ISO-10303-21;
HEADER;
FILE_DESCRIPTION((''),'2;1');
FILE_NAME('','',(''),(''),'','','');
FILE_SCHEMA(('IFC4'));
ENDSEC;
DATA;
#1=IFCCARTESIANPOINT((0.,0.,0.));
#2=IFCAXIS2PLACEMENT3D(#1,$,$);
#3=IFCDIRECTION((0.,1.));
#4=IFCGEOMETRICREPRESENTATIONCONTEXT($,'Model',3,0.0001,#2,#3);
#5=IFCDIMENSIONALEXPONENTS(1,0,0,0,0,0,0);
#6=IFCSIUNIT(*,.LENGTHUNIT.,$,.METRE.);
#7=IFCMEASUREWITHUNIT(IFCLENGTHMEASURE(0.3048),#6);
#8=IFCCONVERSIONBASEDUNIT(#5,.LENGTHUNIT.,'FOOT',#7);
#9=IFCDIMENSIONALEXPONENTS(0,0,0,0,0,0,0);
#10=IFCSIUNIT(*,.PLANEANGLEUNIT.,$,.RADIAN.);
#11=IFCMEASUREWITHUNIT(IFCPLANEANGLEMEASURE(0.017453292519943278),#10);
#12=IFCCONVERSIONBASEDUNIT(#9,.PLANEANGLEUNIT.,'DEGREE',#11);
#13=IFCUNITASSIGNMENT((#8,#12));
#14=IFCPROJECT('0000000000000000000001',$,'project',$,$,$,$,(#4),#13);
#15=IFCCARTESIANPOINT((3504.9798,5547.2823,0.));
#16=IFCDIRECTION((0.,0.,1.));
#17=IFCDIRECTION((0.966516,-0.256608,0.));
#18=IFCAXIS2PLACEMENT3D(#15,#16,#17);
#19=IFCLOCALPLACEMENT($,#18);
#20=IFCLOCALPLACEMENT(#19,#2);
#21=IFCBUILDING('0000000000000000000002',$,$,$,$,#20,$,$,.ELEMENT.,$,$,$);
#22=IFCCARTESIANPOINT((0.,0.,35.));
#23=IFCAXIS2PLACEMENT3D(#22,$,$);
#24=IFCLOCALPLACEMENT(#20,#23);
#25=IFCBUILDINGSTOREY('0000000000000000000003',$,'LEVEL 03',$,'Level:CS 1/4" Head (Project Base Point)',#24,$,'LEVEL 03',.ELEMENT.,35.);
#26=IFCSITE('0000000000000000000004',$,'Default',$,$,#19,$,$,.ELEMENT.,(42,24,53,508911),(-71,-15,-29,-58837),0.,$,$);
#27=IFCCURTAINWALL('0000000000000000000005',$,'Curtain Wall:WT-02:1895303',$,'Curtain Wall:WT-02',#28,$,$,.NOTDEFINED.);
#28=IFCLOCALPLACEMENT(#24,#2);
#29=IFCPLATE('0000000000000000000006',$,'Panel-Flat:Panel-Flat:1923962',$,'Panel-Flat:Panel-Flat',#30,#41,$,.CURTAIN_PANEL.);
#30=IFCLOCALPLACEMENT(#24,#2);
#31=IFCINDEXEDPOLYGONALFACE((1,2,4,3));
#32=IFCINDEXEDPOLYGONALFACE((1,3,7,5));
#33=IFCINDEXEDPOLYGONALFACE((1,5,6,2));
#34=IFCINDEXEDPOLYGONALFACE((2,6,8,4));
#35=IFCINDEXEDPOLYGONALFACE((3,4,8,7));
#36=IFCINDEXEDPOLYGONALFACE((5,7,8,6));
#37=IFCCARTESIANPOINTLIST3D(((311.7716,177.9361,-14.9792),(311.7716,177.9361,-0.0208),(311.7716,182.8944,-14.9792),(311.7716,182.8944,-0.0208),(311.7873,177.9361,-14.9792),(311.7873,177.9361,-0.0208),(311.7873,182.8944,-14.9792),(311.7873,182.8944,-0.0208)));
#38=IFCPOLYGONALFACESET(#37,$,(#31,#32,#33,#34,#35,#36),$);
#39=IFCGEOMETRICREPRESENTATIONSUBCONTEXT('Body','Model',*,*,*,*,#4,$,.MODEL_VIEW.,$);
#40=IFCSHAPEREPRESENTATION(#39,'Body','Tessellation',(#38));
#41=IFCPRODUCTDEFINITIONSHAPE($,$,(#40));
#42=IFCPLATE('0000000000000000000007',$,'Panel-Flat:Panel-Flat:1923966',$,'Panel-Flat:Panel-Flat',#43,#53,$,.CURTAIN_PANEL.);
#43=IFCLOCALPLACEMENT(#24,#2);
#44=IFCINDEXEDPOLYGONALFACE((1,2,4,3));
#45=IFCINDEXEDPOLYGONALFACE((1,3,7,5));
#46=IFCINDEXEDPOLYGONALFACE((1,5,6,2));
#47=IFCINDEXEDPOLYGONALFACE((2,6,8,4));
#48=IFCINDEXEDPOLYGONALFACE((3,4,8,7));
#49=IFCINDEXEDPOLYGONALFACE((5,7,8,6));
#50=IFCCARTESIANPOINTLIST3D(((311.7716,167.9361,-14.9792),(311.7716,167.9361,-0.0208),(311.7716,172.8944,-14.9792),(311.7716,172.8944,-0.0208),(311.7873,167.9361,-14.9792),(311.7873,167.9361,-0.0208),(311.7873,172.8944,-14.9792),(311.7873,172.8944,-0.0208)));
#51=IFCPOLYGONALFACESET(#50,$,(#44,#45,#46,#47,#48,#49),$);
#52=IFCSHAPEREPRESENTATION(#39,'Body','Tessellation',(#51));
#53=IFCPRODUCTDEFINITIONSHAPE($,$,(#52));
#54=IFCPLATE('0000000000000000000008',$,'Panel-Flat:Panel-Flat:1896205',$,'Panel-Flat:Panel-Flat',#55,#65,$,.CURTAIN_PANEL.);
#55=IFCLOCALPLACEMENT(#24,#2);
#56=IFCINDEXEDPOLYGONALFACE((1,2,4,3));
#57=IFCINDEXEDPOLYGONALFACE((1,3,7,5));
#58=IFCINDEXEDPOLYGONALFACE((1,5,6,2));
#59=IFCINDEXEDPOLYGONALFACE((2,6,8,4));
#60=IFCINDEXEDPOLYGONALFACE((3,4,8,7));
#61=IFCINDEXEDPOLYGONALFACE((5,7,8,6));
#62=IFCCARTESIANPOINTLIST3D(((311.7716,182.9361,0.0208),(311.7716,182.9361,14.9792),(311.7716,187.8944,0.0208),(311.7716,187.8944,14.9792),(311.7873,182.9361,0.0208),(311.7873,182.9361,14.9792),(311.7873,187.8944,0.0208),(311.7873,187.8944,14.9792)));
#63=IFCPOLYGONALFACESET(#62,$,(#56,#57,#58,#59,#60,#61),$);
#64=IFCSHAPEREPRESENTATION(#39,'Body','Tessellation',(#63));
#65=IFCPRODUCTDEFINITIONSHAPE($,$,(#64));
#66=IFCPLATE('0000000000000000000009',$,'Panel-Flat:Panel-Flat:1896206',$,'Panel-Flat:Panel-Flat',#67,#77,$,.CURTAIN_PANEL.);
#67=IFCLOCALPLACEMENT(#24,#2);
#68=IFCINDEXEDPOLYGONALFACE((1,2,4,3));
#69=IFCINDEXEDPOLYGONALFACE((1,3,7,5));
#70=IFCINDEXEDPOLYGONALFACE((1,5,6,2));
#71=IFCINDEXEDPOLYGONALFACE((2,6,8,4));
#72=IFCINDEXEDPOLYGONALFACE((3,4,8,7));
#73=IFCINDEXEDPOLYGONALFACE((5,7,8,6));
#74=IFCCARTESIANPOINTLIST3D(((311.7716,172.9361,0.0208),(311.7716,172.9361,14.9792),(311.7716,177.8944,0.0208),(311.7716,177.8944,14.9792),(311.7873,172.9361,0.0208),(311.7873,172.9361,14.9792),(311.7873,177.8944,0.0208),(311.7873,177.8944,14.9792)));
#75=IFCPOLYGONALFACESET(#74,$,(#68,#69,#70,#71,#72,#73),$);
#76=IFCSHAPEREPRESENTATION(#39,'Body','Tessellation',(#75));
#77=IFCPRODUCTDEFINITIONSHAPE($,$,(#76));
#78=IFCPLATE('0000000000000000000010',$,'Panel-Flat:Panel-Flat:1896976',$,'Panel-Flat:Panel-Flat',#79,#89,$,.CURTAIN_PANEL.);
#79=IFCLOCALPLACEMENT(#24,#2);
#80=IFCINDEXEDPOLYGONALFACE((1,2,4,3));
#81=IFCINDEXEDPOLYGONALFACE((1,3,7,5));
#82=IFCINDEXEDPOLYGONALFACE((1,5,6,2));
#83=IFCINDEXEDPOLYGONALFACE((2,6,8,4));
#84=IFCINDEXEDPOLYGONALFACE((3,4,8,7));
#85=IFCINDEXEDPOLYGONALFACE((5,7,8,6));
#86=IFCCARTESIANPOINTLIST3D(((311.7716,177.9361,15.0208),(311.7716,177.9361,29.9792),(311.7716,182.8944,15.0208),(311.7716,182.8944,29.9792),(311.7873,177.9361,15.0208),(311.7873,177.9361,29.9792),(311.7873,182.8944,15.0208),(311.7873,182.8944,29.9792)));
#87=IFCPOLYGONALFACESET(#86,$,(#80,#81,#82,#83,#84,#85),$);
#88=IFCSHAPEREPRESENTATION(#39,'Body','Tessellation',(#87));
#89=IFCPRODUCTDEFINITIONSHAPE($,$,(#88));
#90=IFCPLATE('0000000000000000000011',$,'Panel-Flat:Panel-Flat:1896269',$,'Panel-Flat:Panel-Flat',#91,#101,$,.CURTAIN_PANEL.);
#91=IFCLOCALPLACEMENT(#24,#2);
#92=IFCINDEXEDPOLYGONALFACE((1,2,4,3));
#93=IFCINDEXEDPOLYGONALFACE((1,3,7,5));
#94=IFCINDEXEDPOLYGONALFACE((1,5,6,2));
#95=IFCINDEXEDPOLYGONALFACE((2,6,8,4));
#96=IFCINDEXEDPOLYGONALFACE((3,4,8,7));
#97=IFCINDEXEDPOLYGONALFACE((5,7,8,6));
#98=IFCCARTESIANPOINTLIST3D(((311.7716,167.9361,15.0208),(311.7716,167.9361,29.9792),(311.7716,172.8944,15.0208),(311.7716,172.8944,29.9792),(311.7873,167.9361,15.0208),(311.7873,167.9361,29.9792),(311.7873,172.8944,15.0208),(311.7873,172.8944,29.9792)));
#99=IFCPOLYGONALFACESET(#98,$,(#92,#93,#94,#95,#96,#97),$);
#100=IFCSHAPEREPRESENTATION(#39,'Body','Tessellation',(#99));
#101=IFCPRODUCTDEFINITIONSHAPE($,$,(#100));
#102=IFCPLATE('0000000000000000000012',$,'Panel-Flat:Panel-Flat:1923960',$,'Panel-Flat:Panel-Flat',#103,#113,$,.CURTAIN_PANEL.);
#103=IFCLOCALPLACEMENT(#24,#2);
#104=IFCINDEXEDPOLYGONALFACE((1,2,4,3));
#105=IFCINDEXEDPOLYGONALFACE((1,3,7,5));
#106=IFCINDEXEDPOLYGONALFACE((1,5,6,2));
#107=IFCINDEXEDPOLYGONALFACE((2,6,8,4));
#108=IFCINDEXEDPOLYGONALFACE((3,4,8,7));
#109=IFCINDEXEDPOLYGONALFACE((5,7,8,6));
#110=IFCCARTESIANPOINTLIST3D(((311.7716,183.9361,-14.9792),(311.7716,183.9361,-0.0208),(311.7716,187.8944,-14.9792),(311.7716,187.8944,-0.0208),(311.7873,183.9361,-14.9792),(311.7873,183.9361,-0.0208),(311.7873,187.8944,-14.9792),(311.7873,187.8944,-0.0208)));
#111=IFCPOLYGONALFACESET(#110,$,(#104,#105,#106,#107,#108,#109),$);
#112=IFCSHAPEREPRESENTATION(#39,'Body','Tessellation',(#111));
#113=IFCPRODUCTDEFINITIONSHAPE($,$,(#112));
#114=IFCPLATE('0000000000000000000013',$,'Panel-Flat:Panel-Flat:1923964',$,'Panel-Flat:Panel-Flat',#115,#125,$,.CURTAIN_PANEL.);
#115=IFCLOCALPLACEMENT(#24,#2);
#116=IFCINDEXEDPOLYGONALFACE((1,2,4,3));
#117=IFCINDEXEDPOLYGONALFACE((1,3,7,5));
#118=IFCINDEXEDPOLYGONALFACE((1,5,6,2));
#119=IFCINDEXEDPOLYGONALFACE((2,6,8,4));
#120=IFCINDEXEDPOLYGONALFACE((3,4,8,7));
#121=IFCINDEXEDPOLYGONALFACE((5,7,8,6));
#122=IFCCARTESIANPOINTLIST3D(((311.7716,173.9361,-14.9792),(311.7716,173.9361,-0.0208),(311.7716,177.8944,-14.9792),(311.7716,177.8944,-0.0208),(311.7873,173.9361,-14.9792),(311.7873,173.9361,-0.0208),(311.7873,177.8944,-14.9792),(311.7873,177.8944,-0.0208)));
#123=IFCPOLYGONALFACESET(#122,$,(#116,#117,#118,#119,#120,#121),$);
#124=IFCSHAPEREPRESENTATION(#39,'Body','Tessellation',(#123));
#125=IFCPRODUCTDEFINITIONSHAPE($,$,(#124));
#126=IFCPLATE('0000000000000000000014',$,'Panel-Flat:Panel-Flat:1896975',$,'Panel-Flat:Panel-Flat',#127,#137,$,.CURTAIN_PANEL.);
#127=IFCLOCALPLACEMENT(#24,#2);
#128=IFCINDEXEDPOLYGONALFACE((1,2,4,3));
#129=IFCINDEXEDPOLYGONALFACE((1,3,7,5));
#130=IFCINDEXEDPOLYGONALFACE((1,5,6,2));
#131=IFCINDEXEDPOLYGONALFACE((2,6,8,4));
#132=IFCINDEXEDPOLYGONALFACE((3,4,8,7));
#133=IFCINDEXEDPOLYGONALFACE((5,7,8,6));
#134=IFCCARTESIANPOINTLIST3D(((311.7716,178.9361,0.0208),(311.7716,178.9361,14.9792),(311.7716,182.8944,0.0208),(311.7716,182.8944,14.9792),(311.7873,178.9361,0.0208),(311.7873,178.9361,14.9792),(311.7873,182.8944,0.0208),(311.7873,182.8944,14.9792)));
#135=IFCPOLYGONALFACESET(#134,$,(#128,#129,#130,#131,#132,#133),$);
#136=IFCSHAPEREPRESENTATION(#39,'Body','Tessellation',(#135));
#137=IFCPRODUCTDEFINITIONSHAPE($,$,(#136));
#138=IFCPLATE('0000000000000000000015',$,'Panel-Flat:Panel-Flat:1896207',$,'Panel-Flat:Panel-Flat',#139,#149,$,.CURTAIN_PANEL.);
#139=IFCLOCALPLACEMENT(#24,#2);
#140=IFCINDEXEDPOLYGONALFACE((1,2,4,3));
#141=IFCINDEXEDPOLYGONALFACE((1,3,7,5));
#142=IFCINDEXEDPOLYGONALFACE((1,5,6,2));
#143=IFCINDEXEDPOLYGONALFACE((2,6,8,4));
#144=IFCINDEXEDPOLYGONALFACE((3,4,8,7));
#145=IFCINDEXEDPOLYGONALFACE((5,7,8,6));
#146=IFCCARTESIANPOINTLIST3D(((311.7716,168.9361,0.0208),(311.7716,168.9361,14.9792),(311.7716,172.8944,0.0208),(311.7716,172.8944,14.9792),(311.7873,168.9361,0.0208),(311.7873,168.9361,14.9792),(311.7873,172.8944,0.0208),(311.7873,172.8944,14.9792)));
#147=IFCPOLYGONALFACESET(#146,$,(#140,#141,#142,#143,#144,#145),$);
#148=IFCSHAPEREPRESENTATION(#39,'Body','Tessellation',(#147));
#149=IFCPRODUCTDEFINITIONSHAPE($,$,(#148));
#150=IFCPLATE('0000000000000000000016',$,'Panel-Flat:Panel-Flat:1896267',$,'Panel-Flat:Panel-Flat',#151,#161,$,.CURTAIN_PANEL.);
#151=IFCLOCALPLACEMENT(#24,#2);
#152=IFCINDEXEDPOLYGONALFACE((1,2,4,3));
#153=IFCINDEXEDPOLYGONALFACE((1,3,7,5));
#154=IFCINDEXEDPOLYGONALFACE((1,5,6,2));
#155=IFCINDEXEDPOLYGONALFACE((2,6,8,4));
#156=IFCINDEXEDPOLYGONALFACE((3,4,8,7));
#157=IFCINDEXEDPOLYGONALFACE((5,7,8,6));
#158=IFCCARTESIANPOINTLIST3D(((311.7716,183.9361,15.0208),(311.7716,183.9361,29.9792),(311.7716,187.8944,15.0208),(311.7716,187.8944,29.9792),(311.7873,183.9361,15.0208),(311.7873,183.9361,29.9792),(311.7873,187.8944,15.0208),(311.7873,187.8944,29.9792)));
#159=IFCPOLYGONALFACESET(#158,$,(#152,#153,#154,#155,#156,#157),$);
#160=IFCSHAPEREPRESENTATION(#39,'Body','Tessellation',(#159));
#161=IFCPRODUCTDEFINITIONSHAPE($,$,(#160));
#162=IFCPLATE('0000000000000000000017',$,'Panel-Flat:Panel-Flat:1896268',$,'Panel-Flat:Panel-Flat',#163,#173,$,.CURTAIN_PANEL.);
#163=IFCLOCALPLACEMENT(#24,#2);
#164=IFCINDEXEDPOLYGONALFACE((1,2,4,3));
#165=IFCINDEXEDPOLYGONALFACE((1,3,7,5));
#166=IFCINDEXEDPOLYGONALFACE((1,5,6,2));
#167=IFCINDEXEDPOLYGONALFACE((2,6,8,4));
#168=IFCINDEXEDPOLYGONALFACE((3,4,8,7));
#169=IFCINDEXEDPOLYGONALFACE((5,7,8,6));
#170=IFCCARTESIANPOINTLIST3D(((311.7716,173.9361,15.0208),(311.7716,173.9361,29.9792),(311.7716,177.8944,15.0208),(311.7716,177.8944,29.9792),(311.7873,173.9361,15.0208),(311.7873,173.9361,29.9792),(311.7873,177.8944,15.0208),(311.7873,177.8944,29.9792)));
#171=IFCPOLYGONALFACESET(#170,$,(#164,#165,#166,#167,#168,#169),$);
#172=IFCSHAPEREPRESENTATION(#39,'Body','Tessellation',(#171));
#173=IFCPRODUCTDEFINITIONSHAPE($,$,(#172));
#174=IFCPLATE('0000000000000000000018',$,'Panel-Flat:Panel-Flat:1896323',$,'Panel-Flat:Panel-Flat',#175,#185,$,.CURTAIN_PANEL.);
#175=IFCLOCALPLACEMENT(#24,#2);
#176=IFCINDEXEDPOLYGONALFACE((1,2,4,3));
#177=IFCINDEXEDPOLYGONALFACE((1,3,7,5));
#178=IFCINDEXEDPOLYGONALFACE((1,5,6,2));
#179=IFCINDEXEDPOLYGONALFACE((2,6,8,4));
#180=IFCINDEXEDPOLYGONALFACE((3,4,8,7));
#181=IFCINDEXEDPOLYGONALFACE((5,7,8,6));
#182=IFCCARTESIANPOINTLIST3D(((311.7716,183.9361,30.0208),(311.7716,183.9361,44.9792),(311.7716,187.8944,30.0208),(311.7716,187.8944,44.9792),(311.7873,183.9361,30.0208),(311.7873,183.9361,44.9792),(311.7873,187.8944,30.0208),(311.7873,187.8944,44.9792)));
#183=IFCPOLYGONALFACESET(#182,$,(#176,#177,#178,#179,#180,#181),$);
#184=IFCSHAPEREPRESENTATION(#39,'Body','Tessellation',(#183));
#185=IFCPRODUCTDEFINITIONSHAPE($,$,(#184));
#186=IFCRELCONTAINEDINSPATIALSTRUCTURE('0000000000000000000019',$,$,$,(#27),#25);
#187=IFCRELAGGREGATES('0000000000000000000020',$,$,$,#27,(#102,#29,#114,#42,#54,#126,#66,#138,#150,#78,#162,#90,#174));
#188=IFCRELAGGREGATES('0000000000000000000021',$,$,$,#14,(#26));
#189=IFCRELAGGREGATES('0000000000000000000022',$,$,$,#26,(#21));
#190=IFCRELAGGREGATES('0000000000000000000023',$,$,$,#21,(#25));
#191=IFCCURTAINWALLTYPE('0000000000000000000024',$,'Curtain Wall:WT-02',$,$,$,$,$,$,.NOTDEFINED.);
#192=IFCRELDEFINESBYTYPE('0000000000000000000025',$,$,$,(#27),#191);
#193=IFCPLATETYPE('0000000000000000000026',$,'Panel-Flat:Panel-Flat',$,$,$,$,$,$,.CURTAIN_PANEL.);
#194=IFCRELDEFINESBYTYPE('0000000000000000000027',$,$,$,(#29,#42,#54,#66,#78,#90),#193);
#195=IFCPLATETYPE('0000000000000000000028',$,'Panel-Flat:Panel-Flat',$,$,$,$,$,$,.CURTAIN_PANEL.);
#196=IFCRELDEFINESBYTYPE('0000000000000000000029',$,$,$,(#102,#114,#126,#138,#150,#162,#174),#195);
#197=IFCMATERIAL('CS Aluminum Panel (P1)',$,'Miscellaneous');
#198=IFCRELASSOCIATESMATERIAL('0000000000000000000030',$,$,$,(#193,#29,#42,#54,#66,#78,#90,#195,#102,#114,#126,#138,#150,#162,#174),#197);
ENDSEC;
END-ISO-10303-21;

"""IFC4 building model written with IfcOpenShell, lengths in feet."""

from ifc_helpers import new_model, entity, si_unit, converted_unit, direction, frame, origin, place, context, subcontext, project, spatial, indexed_curve, outline, extrude, source, transform, mapped, material, type_object, type_shapes, element, aggregate, save


model = new_model("IFC4")

# Units and contexts
model_context = context("Model", 3, precision=0.0001, world=origin(), true_north=direction((0.0, 1.0)))
body_context = subcontext(model_context, "Body", "Model", "MODEL_VIEW")
ifc_project = project(units=[converted_unit("LENGTHUNIT", "FOOT", entity("IfcLengthMeasure", 0.3048), si_unit("LENGTHUNIT", "METRE"), dimensions=[1, 0, 0, 0, 0, 0, 0]), converted_unit("PLANEANGLEUNIT", "DEGREE", entity("IfcPlaneAngleMeasure", 0.017453292519943278), si_unit("PLANEANGLEUNIT", "RADIAN"), dimensions=[0, 0, 0, 0, 0, 0, 0])], contexts=[model_context])

# Site, building, storey
site_placement = place(None, frame((3504.9798, 5547.2823, 0.0), z_axis=(0.0, 0.0, 1.0), x_axis=(0.966516, -0.256608, 0.0)))
site = spatial("IfcSite", under=ifc_project, at=site_placement, Name="Default", CompositionType="ELEMENT", RefLatitude=(42, 24, 53, 508911), RefLongitude=(-71, -15, -29, -58837), RefElevation=0.0)
building_placement = place(site_placement, origin())
building = spatial("IfcBuilding", under=site, at=building_placement, CompositionType="ELEMENT")
storey_placement = place(building_placement, frame((0.0, 0.0, 35.0)))
storey = spatial("IfcBuildingStorey", under=building, at=storey_placement, Name="LEVEL 03", ObjectType="Level:CS 1/4\" Head (Project Base Point)", LongName="LEVEL 03", CompositionType="ELEMENT", Elevation=35.0)

# Curtain wall, plates
curtain_wall_type = type_object("IfcCurtainWallType", Name="Curtain Wall:WT-02", PredefinedType="NOTDEFINED")
curtain_wall_placement = place(storey_placement, frame((0.0, 0.0, -35.0)))
curtain_wall = element("IfcCurtainWall", 1, at=curtain_wall_placement, inside=storey, type_object=curtain_wall_type, Name="Curtain Wall:WT-02:1895303", ObjectType="Curtain Wall:WT-02", PredefinedType="NOTDEFINED")
ifc_material = material(Name="CS Aluminum Panel (P1)", Category="Miscellaneous")
plate_type_1 = type_object("IfcPlateType", Name="Panel-Flat:Panel-Flat", PredefinedType="CURTAIN_PANEL", material=ifc_material)
shared_shape_1 = source(origin(), body_context, "Body", "SweptSolid", [
    extrude(outline(indexed_curve([(-0.0078, -2.4792), (0.0078, -2.4792), (0.0078, 2.4792), (-0.0078, 2.4792), (-0.0078, -2.4792)], self_intersect=False)), frame((0.0, -0.0078, 0.0208), z_axis=(0.0, 0.0, 1.0), x_axis=(0.0, -1.0, 0.0)), (0.0, 0.0, 1.0), 14.9583),
])
type_shapes(plate_type_1, [shared_shape_1])
plate_1_placement = place(curtain_wall_placement, frame((311.7873, 180.4153, 20.0), z_axis=(0.0, 0.0, 1.0), x_axis=(0.0, -1.0, 0.0)))
plate_1 = element("IfcPlate", 2, at=plate_1_placement, type_object=plate_type_1, material=ifc_material, Name="Panel-Flat:Panel-Flat:1923962", ObjectType="Panel-Flat:Panel-Flat", PredefinedType="CURTAIN_PANEL", context=body_context, shape_type="MappedRepresentation", body=[
    mapped(shared_shape_1, transform((0.0, 0.0, 0.0), scale=1.0)),
])
plate_2_placement = place(curtain_wall_placement, frame((311.7873, 170.4153, 20.0), z_axis=(0.0, 0.0, 1.0), x_axis=(0.0, -1.0, 0.0)))
plate_2 = element("IfcPlate", 3, at=plate_2_placement, type_object=plate_type_1, material=ifc_material, Name="Panel-Flat:Panel-Flat:1923966", ObjectType="Panel-Flat:Panel-Flat", PredefinedType="CURTAIN_PANEL", context=body_context, shape_type="MappedRepresentation", body=[
    mapped(shared_shape_1, transform((0.0, 0.0, 0.0), scale=1.0)),
])
plate_3_placement = place(curtain_wall_placement, frame((311.7873, 185.4153, 35.0), z_axis=(0.0, 0.0, 1.0), x_axis=(0.0, -1.0, 0.0)))
plate_3 = element("IfcPlate", 4, at=plate_3_placement, type_object=plate_type_1, material=ifc_material, Name="Panel-Flat:Panel-Flat:1896205", ObjectType="Panel-Flat:Panel-Flat", PredefinedType="CURTAIN_PANEL", context=body_context, shape_type="MappedRepresentation", body=[
    mapped(shared_shape_1, transform((0.0, 0.0, 0.0), scale=1.0)),
])
plate_4_placement = place(curtain_wall_placement, frame((311.7873, 175.4153, 35.0), z_axis=(0.0, 0.0, 1.0), x_axis=(0.0, -1.0, 0.0)))
plate_4 = element("IfcPlate", 5, at=plate_4_placement, type_object=plate_type_1, material=ifc_material, Name="Panel-Flat:Panel-Flat:1896206", ObjectType="Panel-Flat:Panel-Flat", PredefinedType="CURTAIN_PANEL", context=body_context, shape_type="MappedRepresentation", body=[
    mapped(shared_shape_1, transform((0.0, 0.0, 0.0), scale=1.0)),
])
plate_5_placement = place(curtain_wall_placement, frame((311.7873, 180.4153, 50.0), z_axis=(0.0, 0.0, 1.0), x_axis=(0.0, -1.0, 0.0)))
plate_5 = element("IfcPlate", 6, at=plate_5_placement, type_object=plate_type_1, material=ifc_material, Name="Panel-Flat:Panel-Flat:1896976", ObjectType="Panel-Flat:Panel-Flat", PredefinedType="CURTAIN_PANEL", context=body_context, shape_type="MappedRepresentation", body=[
    mapped(shared_shape_1, transform((0.0, 0.0, 0.0), scale=1.0)),
])
plate_6_placement = place(curtain_wall_placement, frame((311.7873, 170.4153, 50.0), z_axis=(0.0, 0.0, 1.0), x_axis=(0.0, -1.0, 0.0)))
plate_6 = element("IfcPlate", 7, at=plate_6_placement, type_object=plate_type_1, material=ifc_material, Name="Panel-Flat:Panel-Flat:1896269", ObjectType="Panel-Flat:Panel-Flat", PredefinedType="CURTAIN_PANEL", context=body_context, shape_type="MappedRepresentation", body=[
    mapped(shared_shape_1, transform((0.0, 0.0, 0.0), scale=1.0)),
])
plate_type_2 = type_object("IfcPlateType", Name="Panel-Flat:Panel-Flat", PredefinedType="CURTAIN_PANEL", material=ifc_material)
shared_shape_2 = source(origin(), body_context, "Body", "SweptSolid", [
    extrude(outline(indexed_curve([(-0.0078, -1.9792), (0.0078, -1.9792), (0.0078, 1.9792), (-0.0078, 1.9792), (-0.0078, -1.9792)], self_intersect=False)), frame((0.0, -0.0078, 0.0208), z_axis=(0.0, 0.0, 1.0), x_axis=(0.0, -1.0, 0.0)), (0.0, 0.0, 1.0), 14.9583),
])
type_shapes(plate_type_2, [shared_shape_2])
plate_7_placement = place(curtain_wall_placement, frame((311.7873, 185.9153, 20.0), z_axis=(0.0, 0.0, 1.0), x_axis=(0.0, -1.0, 0.0)))
plate_7 = element("IfcPlate", 8, at=plate_7_placement, type_object=plate_type_2, material=ifc_material, Name="Panel-Flat:Panel-Flat:1923960", ObjectType="Panel-Flat:Panel-Flat", PredefinedType="CURTAIN_PANEL", context=body_context, shape_type="MappedRepresentation", body=[
    mapped(shared_shape_2, transform((0.0, 0.0, 0.0), scale=1.0)),
])
plate_8_placement = place(curtain_wall_placement, frame((311.7873, 175.9153, 20.0), z_axis=(0.0, 0.0, 1.0), x_axis=(0.0, -1.0, 0.0)))
plate_8 = element("IfcPlate", 9, at=plate_8_placement, type_object=plate_type_2, material=ifc_material, Name="Panel-Flat:Panel-Flat:1923964", ObjectType="Panel-Flat:Panel-Flat", PredefinedType="CURTAIN_PANEL", context=body_context, shape_type="MappedRepresentation", body=[
    mapped(shared_shape_2, transform((0.0, 0.0, 0.0), scale=1.0)),
])
plate_9_placement = place(curtain_wall_placement, frame((311.7873, 180.9153, 35.0), z_axis=(0.0, 0.0, 1.0), x_axis=(0.0, -1.0, 0.0)))
plate_9 = element("IfcPlate", 10, at=plate_9_placement, type_object=plate_type_2, material=ifc_material, Name="Panel-Flat:Panel-Flat:1896975", ObjectType="Panel-Flat:Panel-Flat", PredefinedType="CURTAIN_PANEL", context=body_context, shape_type="MappedRepresentation", body=[
    mapped(shared_shape_2, transform((0.0, 0.0, 0.0), scale=1.0)),
])
plate_10_placement = place(curtain_wall_placement, frame((311.7873, 170.9153, 35.0), z_axis=(0.0, 0.0, 1.0), x_axis=(0.0, -1.0, 0.0)))
plate_10 = element("IfcPlate", 11, at=plate_10_placement, type_object=plate_type_2, material=ifc_material, Name="Panel-Flat:Panel-Flat:1896207", ObjectType="Panel-Flat:Panel-Flat", PredefinedType="CURTAIN_PANEL", context=body_context, shape_type="MappedRepresentation", body=[
    mapped(shared_shape_2, transform((0.0, 0.0, 0.0), scale=1.0)),
])
plate_11_placement = place(curtain_wall_placement, frame((311.7873, 185.9153, 50.0), z_axis=(0.0, 0.0, 1.0), x_axis=(0.0, -1.0, 0.0)))
plate_11 = element("IfcPlate", 12, at=plate_11_placement, type_object=plate_type_2, material=ifc_material, Name="Panel-Flat:Panel-Flat:1896267", ObjectType="Panel-Flat:Panel-Flat", PredefinedType="CURTAIN_PANEL", context=body_context, shape_type="MappedRepresentation", body=[
    mapped(shared_shape_2, transform((0.0, 0.0, 0.0), scale=1.0)),
])
plate_12_placement = place(curtain_wall_placement, frame((311.7873, 175.9153, 50.0), z_axis=(0.0, 0.0, 1.0), x_axis=(0.0, -1.0, 0.0)))
plate_12 = element("IfcPlate", 13, at=plate_12_placement, type_object=plate_type_2, material=ifc_material, Name="Panel-Flat:Panel-Flat:1896268", ObjectType="Panel-Flat:Panel-Flat", PredefinedType="CURTAIN_PANEL", context=body_context, shape_type="MappedRepresentation", body=[
    mapped(shared_shape_2, transform((0.0, 0.0, 0.0), scale=1.0)),
])
plate_13_placement = place(curtain_wall_placement, frame((311.7873, 185.9153, 65.0), z_axis=(0.0, 0.0, 1.0), x_axis=(0.0, -1.0, 0.0)))
plate_13 = element("IfcPlate", 14, at=plate_13_placement, type_object=plate_type_2, material=ifc_material, Name="Panel-Flat:Panel-Flat:1896323", ObjectType="Panel-Flat:Panel-Flat", PredefinedType="CURTAIN_PANEL", context=body_context, shape_type="MappedRepresentation", body=[
    mapped(shared_shape_2, transform((0.0, 0.0, 0.0), scale=1.0)),
])
aggregate(curtain_wall, [plate_7, plate_1, plate_8, plate_2, plate_3, plate_9, plate_4, plate_10, plate_11, plate_5, plate_12, plate_6, plate_13])

save(model, "model.ifc")
